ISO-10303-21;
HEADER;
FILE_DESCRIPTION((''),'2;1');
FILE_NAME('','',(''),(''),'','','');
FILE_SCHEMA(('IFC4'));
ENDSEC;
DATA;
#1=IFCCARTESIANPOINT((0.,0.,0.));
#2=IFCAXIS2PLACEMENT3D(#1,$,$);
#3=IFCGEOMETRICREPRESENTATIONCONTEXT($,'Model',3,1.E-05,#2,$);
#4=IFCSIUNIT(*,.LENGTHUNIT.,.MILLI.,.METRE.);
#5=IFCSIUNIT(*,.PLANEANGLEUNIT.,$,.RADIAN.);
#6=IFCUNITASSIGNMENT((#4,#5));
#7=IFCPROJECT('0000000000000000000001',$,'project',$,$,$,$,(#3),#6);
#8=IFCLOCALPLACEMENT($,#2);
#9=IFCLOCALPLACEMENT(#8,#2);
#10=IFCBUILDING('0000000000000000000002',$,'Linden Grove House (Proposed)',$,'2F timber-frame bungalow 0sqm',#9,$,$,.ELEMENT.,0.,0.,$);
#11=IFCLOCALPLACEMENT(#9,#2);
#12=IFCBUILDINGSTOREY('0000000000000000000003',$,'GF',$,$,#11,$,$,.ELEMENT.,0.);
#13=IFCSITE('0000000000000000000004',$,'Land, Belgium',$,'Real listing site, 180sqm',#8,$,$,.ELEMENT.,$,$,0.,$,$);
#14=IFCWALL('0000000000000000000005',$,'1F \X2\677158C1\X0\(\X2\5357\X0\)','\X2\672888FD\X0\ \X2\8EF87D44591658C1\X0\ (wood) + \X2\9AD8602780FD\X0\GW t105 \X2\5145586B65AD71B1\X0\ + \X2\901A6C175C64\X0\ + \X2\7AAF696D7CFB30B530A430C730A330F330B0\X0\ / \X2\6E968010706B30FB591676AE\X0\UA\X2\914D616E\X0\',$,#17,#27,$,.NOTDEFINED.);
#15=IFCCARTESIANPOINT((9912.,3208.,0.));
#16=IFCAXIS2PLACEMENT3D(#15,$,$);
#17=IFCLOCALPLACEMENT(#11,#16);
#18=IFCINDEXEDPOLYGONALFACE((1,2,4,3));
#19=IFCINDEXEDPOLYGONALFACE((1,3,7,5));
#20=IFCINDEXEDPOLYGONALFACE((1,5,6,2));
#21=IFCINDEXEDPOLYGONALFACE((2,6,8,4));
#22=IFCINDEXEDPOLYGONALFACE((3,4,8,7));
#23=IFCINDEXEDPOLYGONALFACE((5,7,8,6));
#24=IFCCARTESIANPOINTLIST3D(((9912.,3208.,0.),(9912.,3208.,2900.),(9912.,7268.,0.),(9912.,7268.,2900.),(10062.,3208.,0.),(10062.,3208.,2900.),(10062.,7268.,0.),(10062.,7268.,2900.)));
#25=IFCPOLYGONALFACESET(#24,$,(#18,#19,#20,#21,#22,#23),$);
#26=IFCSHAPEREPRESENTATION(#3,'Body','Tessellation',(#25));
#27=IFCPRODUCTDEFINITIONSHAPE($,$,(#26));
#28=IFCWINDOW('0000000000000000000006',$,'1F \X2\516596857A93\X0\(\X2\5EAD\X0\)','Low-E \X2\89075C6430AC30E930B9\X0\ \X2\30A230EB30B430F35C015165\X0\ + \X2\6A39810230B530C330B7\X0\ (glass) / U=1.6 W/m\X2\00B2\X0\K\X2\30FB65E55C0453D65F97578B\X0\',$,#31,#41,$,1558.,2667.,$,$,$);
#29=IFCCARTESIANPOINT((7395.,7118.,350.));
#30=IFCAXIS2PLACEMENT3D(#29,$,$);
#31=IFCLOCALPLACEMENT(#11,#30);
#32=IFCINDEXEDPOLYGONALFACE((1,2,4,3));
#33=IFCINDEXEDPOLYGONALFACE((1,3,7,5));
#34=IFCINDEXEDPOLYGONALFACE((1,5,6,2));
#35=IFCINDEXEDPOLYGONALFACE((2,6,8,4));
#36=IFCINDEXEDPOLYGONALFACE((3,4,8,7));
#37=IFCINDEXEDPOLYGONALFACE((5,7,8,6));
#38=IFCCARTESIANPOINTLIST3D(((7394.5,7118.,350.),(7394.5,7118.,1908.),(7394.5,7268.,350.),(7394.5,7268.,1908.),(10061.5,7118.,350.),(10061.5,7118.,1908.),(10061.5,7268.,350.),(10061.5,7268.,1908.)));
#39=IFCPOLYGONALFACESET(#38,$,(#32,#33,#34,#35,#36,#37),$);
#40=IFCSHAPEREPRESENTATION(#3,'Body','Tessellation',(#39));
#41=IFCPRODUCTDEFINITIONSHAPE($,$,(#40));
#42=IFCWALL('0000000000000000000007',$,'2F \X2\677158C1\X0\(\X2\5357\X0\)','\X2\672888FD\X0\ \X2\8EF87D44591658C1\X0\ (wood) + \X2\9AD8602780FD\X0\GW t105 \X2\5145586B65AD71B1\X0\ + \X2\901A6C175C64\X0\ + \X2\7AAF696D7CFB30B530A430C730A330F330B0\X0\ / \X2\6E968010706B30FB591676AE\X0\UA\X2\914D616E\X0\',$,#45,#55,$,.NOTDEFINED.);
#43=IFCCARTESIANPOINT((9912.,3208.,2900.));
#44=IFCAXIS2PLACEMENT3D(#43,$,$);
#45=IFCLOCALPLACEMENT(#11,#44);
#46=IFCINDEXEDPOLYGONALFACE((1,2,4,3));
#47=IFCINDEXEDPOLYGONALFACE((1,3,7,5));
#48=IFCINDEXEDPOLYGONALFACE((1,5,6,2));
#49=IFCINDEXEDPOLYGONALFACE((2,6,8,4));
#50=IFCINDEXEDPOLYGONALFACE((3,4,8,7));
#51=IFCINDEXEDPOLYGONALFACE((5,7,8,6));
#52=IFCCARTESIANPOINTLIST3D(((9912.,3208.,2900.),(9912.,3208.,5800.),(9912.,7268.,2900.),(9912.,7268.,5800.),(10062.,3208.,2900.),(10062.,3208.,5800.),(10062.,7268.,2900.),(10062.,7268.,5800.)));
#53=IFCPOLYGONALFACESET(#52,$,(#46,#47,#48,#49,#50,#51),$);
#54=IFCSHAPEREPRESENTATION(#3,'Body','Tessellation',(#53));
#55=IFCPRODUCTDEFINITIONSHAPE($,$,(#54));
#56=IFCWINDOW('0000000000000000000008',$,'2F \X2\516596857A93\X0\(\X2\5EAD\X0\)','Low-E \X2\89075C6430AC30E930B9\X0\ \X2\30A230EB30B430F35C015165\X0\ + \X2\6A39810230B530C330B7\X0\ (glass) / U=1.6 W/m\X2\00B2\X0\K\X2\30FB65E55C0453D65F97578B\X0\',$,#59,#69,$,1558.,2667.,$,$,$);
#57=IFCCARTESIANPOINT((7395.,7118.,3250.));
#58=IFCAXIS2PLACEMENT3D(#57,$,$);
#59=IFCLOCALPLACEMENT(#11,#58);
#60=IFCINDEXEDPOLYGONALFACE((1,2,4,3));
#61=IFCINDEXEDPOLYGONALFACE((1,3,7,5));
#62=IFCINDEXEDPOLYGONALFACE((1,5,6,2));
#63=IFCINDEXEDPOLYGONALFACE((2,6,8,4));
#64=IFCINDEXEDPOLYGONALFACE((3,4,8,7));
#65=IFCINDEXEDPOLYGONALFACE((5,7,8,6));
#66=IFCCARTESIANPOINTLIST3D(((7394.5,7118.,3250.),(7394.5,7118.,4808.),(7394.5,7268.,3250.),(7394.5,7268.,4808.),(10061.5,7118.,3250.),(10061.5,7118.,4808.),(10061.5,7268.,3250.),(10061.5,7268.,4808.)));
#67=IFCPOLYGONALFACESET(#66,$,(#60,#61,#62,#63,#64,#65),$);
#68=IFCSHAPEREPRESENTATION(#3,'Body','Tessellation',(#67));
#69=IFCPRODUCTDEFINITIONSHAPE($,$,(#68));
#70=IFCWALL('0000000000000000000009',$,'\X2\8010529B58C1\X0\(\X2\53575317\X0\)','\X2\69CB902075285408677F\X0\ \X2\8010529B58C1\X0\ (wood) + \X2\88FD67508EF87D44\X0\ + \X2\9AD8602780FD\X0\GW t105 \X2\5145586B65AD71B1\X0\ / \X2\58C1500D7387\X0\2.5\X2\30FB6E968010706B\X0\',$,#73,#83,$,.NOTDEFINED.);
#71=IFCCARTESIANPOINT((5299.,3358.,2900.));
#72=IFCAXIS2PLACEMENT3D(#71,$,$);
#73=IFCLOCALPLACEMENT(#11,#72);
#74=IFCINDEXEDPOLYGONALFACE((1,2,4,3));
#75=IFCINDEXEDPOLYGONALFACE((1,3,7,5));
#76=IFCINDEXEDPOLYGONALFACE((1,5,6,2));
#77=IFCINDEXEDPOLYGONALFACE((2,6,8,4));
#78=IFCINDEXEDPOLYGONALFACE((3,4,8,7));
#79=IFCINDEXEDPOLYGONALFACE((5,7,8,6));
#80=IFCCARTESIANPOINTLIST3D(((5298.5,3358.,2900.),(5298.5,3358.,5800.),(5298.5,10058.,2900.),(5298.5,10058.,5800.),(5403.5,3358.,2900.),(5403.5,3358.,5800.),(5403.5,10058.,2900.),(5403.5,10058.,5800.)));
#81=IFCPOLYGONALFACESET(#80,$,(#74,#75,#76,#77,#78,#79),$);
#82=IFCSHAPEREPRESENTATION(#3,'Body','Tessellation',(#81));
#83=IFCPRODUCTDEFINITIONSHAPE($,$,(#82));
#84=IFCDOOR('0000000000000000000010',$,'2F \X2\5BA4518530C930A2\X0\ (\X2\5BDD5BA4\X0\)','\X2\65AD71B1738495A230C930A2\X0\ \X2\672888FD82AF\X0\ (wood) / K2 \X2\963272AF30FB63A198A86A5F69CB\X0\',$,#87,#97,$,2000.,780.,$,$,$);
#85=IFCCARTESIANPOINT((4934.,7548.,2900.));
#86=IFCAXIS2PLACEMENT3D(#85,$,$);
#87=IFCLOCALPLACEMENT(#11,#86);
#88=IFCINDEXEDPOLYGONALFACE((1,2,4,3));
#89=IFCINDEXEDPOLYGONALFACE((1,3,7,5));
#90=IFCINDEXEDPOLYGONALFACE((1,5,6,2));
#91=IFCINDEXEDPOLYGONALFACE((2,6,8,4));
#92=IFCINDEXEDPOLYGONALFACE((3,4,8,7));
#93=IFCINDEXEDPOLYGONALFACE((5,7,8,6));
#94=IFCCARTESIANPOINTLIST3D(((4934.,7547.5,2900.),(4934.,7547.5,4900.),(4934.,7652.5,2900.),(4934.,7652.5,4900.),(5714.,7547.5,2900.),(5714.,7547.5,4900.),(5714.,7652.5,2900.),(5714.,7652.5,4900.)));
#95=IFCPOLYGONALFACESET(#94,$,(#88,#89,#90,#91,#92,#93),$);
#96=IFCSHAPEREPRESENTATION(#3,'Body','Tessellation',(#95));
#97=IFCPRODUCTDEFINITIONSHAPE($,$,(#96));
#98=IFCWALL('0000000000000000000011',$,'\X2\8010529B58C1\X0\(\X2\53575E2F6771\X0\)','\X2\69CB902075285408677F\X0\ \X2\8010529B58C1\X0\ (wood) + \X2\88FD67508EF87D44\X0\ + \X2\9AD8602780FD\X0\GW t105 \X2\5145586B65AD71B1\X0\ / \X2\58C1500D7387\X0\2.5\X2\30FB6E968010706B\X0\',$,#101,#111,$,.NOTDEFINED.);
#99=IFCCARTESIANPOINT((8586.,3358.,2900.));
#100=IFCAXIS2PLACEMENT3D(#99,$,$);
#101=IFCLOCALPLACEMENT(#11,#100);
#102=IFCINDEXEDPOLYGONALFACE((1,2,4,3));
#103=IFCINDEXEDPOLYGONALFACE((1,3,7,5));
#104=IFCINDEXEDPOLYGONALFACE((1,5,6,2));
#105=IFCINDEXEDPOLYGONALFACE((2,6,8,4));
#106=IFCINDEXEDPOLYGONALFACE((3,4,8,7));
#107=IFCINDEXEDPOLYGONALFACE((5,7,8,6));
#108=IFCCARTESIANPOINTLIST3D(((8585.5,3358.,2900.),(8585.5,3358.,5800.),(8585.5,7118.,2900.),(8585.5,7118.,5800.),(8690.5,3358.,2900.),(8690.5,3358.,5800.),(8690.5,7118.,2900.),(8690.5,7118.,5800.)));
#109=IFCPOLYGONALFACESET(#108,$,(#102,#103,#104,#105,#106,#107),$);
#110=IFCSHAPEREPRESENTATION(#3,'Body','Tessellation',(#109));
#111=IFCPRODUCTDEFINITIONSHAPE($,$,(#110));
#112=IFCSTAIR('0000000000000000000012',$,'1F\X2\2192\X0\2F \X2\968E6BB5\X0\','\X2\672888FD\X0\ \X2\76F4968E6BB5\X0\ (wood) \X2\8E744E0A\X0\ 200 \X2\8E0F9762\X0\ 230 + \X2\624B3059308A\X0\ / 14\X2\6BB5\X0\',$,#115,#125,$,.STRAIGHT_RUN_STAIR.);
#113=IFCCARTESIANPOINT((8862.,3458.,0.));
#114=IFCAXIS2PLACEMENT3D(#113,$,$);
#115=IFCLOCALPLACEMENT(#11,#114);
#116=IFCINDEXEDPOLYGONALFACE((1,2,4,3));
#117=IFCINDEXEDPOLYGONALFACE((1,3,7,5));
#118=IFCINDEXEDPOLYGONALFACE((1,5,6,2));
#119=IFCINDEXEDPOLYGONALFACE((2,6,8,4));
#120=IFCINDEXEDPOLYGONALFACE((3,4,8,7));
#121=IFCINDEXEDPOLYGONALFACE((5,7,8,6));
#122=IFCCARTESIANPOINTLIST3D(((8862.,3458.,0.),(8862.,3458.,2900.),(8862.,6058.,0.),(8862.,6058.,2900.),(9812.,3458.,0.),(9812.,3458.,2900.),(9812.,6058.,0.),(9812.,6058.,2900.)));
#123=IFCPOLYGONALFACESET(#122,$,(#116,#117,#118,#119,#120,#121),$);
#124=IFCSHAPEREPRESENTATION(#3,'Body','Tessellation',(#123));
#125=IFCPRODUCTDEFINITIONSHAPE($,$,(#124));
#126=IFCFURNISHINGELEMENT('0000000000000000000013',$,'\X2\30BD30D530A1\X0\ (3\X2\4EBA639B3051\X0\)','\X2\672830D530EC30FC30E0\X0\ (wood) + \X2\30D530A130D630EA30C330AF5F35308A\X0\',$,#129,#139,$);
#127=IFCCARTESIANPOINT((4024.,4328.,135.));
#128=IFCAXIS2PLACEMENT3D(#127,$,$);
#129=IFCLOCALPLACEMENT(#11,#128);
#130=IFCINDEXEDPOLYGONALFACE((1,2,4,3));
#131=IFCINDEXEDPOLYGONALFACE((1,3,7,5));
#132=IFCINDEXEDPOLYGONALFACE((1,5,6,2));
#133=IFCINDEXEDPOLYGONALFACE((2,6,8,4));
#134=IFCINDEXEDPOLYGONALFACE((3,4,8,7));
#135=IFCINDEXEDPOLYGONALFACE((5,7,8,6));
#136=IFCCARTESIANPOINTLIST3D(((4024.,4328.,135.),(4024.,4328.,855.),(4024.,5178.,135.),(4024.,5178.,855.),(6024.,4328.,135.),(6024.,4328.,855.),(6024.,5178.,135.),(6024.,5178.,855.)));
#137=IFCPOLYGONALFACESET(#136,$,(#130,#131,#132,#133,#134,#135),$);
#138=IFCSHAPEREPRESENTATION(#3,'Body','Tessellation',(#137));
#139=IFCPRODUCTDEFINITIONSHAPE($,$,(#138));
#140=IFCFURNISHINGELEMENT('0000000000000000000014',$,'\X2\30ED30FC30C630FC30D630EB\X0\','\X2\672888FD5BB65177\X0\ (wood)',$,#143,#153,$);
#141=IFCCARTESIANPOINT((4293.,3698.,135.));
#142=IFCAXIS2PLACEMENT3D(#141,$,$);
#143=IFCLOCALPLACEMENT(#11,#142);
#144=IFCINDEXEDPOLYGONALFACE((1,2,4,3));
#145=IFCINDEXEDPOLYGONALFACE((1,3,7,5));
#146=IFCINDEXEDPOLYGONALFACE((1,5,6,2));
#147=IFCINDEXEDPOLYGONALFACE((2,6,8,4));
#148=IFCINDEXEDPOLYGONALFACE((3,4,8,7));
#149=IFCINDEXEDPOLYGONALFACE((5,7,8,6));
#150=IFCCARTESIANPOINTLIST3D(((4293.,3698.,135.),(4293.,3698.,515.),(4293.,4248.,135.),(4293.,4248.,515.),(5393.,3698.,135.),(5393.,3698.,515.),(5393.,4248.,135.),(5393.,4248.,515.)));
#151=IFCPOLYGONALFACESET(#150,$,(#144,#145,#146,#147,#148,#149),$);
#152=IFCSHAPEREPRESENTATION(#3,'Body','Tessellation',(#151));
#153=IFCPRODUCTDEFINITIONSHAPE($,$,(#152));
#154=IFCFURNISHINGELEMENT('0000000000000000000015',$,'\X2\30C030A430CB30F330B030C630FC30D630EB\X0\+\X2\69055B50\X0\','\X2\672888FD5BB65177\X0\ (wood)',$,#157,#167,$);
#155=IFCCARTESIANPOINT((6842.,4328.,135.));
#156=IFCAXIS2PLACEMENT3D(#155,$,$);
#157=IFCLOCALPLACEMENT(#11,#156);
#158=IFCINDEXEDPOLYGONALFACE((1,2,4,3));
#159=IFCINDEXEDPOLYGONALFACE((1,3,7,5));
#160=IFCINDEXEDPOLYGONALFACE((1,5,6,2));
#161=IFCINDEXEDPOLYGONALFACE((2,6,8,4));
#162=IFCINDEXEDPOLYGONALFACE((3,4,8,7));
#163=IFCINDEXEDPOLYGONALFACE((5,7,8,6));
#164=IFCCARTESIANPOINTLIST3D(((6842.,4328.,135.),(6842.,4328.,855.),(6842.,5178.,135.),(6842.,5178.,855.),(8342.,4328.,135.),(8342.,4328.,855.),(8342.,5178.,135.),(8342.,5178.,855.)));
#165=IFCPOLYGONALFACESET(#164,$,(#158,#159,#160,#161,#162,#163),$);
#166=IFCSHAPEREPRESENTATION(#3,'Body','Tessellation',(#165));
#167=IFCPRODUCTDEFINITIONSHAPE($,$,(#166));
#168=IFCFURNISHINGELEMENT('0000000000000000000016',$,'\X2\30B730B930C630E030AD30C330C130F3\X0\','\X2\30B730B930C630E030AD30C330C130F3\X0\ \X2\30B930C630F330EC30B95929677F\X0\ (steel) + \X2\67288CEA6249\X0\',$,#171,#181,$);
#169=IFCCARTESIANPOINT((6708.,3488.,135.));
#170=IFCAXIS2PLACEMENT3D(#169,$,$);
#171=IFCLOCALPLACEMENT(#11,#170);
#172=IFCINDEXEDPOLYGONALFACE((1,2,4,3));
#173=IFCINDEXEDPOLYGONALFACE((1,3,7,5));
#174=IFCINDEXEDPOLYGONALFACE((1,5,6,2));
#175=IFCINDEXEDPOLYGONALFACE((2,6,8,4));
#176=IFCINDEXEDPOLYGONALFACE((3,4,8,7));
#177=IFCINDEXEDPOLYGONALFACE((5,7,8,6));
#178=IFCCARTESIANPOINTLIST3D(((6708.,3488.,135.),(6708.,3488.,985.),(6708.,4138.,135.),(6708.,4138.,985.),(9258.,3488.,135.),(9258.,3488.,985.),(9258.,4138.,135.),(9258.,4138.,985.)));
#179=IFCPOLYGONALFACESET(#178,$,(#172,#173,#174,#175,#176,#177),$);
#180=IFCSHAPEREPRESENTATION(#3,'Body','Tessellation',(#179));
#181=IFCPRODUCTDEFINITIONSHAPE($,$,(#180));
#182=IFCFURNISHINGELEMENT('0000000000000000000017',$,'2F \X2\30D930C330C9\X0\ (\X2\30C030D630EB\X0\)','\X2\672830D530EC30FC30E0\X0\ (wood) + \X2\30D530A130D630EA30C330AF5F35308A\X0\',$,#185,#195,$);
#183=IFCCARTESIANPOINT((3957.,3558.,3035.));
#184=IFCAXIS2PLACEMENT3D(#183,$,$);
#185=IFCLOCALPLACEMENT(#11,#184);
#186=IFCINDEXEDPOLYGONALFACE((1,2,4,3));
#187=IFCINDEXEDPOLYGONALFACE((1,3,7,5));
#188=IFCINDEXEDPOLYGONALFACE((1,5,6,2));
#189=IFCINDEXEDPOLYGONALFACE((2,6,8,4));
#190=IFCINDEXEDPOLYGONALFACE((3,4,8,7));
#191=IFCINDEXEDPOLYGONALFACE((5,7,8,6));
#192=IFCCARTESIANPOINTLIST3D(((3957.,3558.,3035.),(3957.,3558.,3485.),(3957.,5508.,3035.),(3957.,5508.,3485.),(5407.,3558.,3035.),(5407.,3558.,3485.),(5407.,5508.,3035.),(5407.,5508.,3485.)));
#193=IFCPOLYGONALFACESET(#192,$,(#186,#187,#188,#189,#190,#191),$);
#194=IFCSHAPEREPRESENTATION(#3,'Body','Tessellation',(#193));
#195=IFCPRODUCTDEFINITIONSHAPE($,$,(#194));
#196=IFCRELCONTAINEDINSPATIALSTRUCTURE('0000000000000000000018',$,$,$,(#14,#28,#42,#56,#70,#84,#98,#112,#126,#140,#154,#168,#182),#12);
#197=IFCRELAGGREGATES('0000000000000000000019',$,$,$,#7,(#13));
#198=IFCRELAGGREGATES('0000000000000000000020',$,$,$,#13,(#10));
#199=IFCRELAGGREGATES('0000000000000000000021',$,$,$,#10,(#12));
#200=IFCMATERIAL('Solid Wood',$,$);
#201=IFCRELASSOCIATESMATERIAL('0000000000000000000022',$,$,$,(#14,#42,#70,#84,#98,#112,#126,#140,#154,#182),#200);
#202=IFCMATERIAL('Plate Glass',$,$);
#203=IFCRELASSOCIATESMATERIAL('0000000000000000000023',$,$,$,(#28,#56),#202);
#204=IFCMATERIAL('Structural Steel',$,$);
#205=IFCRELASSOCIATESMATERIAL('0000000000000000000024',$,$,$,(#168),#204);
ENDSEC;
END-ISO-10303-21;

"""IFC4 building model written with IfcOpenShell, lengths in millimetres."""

from ifc_helpers import new_model, si_unit, frame, frame_2d, origin, place, context, project, spatial, rectangle, extrude, material, element, fill, save


model = new_model("IFC4")

# Units and contexts
model_context = context("Model", 3, precision=1e-05, world=origin())
ifc_project = project(units=[si_unit("LENGTHUNIT", "METRE", prefix="MILLI"), si_unit("PLANEANGLEUNIT", "RADIAN")], contexts=[model_context])

# Site, building, storey
site_placement = place(None, origin())
site = spatial("IfcSite", under=ifc_project, at=site_placement, Name="Land, Belgium", ObjectType="Real listing site, 180sqm", CompositionType="ELEMENT", RefElevation=0.0)
building_placement = place(site_placement, origin())
building = spatial("IfcBuilding", under=site, at=building_placement, Name="Linden Grove House (Proposed)", ObjectType="2F timber-frame bungalow 0sqm", CompositionType="ELEMENT", ElevationOfRefHeight=0.0, ElevationOfTerrain=0.0)
storey_placement = place(building_placement, origin())
storey = spatial("IfcBuildingStorey", under=building, at=storey_placement, Name="GF", CompositionType="ELEMENT", Elevation=0.0)

# Wall, opening, window
ifc_material_1 = material(Name="Solid Wood")
wall_1_placement = place(storey_placement, frame((9912.0, 3208.0, 0.0)))
wall_1 = element("IfcWall", 1, at=wall_1_placement, inside=storey, material=ifc_material_1, Name="1F 東壁(南)", Description="木製 軸組外壁 (wood) + 高性能GW t105 充填断熱 + 通気層 + 窯業系サイディング / 準耐火・外皮UA配慮", PredefinedType="NOTDEFINED", context=model_context, shape_type="SweptSolid", body=[
    extrude(rectangle(XDim=150.0, YDim=4060.0, at=frame_2d((75.0, 2030.0))), frame((9912.0, 3208.0, 0.0)), (0.0, 0.0, 1.0), 2900.0),
])
opening_1_placement = place(storey_placement, frame((7395.0, 7118.0, 350.0)))
opening_1 = element("IfcOpeningElement", 2, at=opening_1_placement, cuts=wall_1, PredefinedType="NOTDEFINED", context=model_context, shape_type="SweptSolid", body=[
    extrude(rectangle(XDim=2667.0, YDim=150.0, at=frame_2d((1333.0, 75.0))), frame((7395.0, 7118.0, 350.0)), (0.0, 0.0, 1.0), 1558.0),
])
ifc_material_2 = material(Name="Plate Glass")
window_1_placement = place(storey_placement, frame((7395.0, 7118.0, 350.0)))
window_1 = element("IfcWindow", 3, at=window_1_placement, inside=storey, material=ifc_material_2, Name="1F 入隅窓(庭)", Description="Low-E 複層ガラス アルゴン封入 + 樹脂サッシ (glass) / U=1.6 W/m²K・日射取得型", OverallHeight=1558.0, OverallWidth=2667.0, context=model_context, shape_type="SweptSolid", body=[
    extrude(rectangle(XDim=2667.0, YDim=150.0, at=frame_2d((1333.0, 75.0))), frame((7395.0, 7118.0, 350.0)), (0.0, 0.0, 1.0), 1558.0),
])
fill(opening_1, window_1)

# Wall, opening, window
wall_2_placement = place(storey_placement, frame((9912.0, 3208.0, 2900.0)))
wall_2 = element("IfcWall", 4, at=wall_2_placement, inside=storey, material=ifc_material_1, Name="2F 東壁(南)", Description="木製 軸組外壁 (wood) + 高性能GW t105 充填断熱 + 通気層 + 窯業系サイディング / 準耐火・外皮UA配慮", PredefinedType="NOTDEFINED", context=model_context, shape_type="SweptSolid", body=[
    extrude(rectangle(XDim=150.0, YDim=4060.0, at=frame_2d((75.0, 2030.0))), frame((9912.0, 3208.0, 2900.0)), (0.0, 0.0, 1.0), 2900.0),
])
opening_2_placement = place(storey_placement, frame((7395.0, 7118.0, 3250.0)))
opening_2 = element("IfcOpeningElement", 5, at=opening_2_placement, cuts=wall_2, PredefinedType="NOTDEFINED", context=model_context, shape_type="SweptSolid", body=[
    extrude(rectangle(XDim=2667.0, YDim=150.0, at=frame_2d((1333.0, 75.0))), frame((7395.0, 7118.0, 3250.0)), (0.0, 0.0, 1.0), 1558.0),
])
window_2_placement = place(storey_placement, frame((7395.0, 7118.0, 3250.0)))
window_2 = element("IfcWindow", 6, at=window_2_placement, inside=storey, material=ifc_material_2, Name="2F 入隅窓(庭)", Description="Low-E 複層ガラス アルゴン封入 + 樹脂サッシ (glass) / U=1.6 W/m²K・日射取得型", OverallHeight=1558.0, OverallWidth=2667.0, context=model_context, shape_type="SweptSolid", body=[
    extrude(rectangle(XDim=2667.0, YDim=150.0, at=frame_2d((1333.0, 75.0))), frame((7395.0, 7118.0, 3250.0)), (0.0, 0.0, 1.0), 1558.0),
])
fill(opening_2, window_2)

# Wall, opening, door
wall_3_placement = place(storey_placement, frame((5299.0, 3358.0, 2900.0)))
wall_3 = element("IfcWall", 7, at=wall_3_placement, inside=storey, material=ifc_material_1, Name="耐力壁(南北)", Description="構造用合板 耐力壁 (wood) + 製材軸組 + 高性能GW t105 充填断熱 / 壁倍率2.5・準耐火", PredefinedType="NOTDEFINED", context=model_context, shape_type="SweptSolid", body=[
    extrude(rectangle(XDim=105.0, YDim=6700.0, at=frame_2d((52.0, 3350.0))), frame((5299.0, 3358.0, 2900.0)), (0.0, 0.0, 1.0), 2900.0),
])
opening_3_placement = place(storey_placement, frame((4934.0, 7548.0, 2900.0)))
opening_3 = element("IfcOpeningElement", 8, at=opening_3_placement, cuts=wall_3, PredefinedType="NOTDEFINED", context=model_context, shape_type="SweptSolid", body=[
    extrude(rectangle(XDim=780.0, YDim=105.0, at=frame_2d((390.0, 52.0))), frame((4934.0, 7548.0, 2900.0)), (0.0, 0.0, 1.0), 2000.0),
])
door_1_placement = place(storey_placement, frame((4934.0, 7548.0, 2900.0)))
door_1 = element("IfcDoor", 9, at=door_1_placement, inside=storey, material=ifc_material_1, Name="2F 室内ドア (寝室)", Description="断熱玄関ドア 木製芯 (wood) / K2 防犯・採風機構", OverallHeight=2000.0, OverallWidth=780.0, context=model_context, shape_type="SweptSolid", body=[
    extrude(rectangle(XDim=780.0, YDim=105.0, at=frame_2d((390.0, 52.0))), frame((4934.0, 7548.0, 2900.0)), (0.0, 0.0, 1.0), 2000.0),
])
fill(opening_3, door_1)

# Wall
wall_4_placement = place(storey_placement, frame((8586.0, 3358.0, 2900.0)))
element("IfcWall", 10, at=wall_4_placement, inside=storey, material=ifc_material_1, Name="耐力壁(南帯東)", Description="構造用合板 耐力壁 (wood) + 製材軸組 + 高性能GW t105 充填断熱 / 壁倍率2.5・準耐火", PredefinedType="NOTDEFINED", context=model_context, shape_type="SweptSolid", body=[
    extrude(rectangle(XDim=105.0, YDim=3760.0, at=frame_2d((52.0, 1880.0))), frame((8586.0, 3358.0, 2900.0)), (0.0, 0.0, 1.0), 2900.0),
])

# Stair
stair_placement = place(storey_placement, frame((8862.0, 3458.0, 0.0)))
element("IfcStair", 11, at=stair_placement, inside=storey, material=ifc_material_1, Name="1F→2F 階段", Description="木製 直階段 (wood) 蹴上 200 踏面 230 + 手すり / 14段", PredefinedType="STRAIGHT_RUN_STAIR", context=model_context, shape_type="SweptSolid", body=[
    extrude(rectangle(XDim=950.0, YDim=2600.0, at=frame_2d((475.0, 1300.0))), frame((8862.0, 3458.0, 0.0)), (0.0, 0.0, 1.0), 2900.0),
])

# Furnishing elements
furnishing_1_placement = place(storey_placement, frame((4024.0, 4328.0, 135.0)))
element("IfcFurnishingElement", 12, at=furnishing_1_placement, inside=storey, material=ifc_material_1, Name="ソファ (3人掛け)", Description="木フレーム (wood) + ファブリック張り", context=model_context, shape_type="SweptSolid", body=[
    extrude(rectangle(XDim=2000.0, YDim=850.0, at=frame_2d((1000.0, 425.0))), frame((4024.0, 4328.0, 135.0)), (0.0, 0.0, 1.0), 720.0),
])
furnishing_2_placement = place(storey_placement, frame((4293.0, 3698.0, 135.0)))
element("IfcFurnishingElement", 13, at=furnishing_2_placement, inside=storey, material=ifc_material_1, Name="ローテーブル", Description="木製家具 (wood)", context=model_context, shape_type="SweptSolid", body=[
    extrude(rectangle(XDim=1100.0, YDim=550.0, at=frame_2d((550.0, 275.0))), frame((4293.0, 3698.0, 135.0)), (0.0, 0.0, 1.0), 380.0),
])
furnishing_3_placement = place(storey_placement, frame((6842.0, 4328.0, 135.0)))
element("IfcFurnishingElement", 14, at=furnishing_3_placement, inside=storey, material=ifc_material_1, Name="ダイニングテーブル+椅子", Description="木製家具 (wood)", context=model_context, shape_type="SweptSolid", body=[
    extrude(rectangle(XDim=1500.0, YDim=850.0, at=frame_2d((750.0, 425.0))), frame((6842.0, 4328.0, 135.0)), (0.0, 0.0, 1.0), 720.0),
])
ifc_material_3 = material(Name="Structural Steel")
furnishing_4_placement = place(storey_placement, frame((6708.0, 3488.0, 135.0)))
element("IfcFurnishingElement", 15, at=furnishing_4_placement, inside=storey, material=ifc_material_3, Name="システムキッチン", Description="システムキッチン ステンレス天板 (steel) + 木質扉", context=model_context, shape_type="SweptSolid", body=[
    extrude(rectangle(XDim=2550.0, YDim=650.0, at=frame_2d((1275.0, 325.0))), frame((6708.0, 3488.0, 135.0)), (0.0, 0.0, 1.0), 850.0),
])
furnishing_5_placement = place(storey_placement, frame((3957.0, 3558.0, 3035.0)))
element("IfcFurnishingElement", 16, at=furnishing_5_placement, inside=storey, material=ifc_material_1, Name="2F ベッド (ダブル)", Description="木フレーム (wood) + ファブリック張り", context=model_context, shape_type="SweptSolid", body=[
    extrude(rectangle(XDim=1450.0, YDim=1950.0, at=frame_2d((725.0, 975.0))), frame((3957.0, 3558.0, 3035.0)), (0.0, 0.0, 1.0), 450.0),
])

save(model, "model.ifc")
